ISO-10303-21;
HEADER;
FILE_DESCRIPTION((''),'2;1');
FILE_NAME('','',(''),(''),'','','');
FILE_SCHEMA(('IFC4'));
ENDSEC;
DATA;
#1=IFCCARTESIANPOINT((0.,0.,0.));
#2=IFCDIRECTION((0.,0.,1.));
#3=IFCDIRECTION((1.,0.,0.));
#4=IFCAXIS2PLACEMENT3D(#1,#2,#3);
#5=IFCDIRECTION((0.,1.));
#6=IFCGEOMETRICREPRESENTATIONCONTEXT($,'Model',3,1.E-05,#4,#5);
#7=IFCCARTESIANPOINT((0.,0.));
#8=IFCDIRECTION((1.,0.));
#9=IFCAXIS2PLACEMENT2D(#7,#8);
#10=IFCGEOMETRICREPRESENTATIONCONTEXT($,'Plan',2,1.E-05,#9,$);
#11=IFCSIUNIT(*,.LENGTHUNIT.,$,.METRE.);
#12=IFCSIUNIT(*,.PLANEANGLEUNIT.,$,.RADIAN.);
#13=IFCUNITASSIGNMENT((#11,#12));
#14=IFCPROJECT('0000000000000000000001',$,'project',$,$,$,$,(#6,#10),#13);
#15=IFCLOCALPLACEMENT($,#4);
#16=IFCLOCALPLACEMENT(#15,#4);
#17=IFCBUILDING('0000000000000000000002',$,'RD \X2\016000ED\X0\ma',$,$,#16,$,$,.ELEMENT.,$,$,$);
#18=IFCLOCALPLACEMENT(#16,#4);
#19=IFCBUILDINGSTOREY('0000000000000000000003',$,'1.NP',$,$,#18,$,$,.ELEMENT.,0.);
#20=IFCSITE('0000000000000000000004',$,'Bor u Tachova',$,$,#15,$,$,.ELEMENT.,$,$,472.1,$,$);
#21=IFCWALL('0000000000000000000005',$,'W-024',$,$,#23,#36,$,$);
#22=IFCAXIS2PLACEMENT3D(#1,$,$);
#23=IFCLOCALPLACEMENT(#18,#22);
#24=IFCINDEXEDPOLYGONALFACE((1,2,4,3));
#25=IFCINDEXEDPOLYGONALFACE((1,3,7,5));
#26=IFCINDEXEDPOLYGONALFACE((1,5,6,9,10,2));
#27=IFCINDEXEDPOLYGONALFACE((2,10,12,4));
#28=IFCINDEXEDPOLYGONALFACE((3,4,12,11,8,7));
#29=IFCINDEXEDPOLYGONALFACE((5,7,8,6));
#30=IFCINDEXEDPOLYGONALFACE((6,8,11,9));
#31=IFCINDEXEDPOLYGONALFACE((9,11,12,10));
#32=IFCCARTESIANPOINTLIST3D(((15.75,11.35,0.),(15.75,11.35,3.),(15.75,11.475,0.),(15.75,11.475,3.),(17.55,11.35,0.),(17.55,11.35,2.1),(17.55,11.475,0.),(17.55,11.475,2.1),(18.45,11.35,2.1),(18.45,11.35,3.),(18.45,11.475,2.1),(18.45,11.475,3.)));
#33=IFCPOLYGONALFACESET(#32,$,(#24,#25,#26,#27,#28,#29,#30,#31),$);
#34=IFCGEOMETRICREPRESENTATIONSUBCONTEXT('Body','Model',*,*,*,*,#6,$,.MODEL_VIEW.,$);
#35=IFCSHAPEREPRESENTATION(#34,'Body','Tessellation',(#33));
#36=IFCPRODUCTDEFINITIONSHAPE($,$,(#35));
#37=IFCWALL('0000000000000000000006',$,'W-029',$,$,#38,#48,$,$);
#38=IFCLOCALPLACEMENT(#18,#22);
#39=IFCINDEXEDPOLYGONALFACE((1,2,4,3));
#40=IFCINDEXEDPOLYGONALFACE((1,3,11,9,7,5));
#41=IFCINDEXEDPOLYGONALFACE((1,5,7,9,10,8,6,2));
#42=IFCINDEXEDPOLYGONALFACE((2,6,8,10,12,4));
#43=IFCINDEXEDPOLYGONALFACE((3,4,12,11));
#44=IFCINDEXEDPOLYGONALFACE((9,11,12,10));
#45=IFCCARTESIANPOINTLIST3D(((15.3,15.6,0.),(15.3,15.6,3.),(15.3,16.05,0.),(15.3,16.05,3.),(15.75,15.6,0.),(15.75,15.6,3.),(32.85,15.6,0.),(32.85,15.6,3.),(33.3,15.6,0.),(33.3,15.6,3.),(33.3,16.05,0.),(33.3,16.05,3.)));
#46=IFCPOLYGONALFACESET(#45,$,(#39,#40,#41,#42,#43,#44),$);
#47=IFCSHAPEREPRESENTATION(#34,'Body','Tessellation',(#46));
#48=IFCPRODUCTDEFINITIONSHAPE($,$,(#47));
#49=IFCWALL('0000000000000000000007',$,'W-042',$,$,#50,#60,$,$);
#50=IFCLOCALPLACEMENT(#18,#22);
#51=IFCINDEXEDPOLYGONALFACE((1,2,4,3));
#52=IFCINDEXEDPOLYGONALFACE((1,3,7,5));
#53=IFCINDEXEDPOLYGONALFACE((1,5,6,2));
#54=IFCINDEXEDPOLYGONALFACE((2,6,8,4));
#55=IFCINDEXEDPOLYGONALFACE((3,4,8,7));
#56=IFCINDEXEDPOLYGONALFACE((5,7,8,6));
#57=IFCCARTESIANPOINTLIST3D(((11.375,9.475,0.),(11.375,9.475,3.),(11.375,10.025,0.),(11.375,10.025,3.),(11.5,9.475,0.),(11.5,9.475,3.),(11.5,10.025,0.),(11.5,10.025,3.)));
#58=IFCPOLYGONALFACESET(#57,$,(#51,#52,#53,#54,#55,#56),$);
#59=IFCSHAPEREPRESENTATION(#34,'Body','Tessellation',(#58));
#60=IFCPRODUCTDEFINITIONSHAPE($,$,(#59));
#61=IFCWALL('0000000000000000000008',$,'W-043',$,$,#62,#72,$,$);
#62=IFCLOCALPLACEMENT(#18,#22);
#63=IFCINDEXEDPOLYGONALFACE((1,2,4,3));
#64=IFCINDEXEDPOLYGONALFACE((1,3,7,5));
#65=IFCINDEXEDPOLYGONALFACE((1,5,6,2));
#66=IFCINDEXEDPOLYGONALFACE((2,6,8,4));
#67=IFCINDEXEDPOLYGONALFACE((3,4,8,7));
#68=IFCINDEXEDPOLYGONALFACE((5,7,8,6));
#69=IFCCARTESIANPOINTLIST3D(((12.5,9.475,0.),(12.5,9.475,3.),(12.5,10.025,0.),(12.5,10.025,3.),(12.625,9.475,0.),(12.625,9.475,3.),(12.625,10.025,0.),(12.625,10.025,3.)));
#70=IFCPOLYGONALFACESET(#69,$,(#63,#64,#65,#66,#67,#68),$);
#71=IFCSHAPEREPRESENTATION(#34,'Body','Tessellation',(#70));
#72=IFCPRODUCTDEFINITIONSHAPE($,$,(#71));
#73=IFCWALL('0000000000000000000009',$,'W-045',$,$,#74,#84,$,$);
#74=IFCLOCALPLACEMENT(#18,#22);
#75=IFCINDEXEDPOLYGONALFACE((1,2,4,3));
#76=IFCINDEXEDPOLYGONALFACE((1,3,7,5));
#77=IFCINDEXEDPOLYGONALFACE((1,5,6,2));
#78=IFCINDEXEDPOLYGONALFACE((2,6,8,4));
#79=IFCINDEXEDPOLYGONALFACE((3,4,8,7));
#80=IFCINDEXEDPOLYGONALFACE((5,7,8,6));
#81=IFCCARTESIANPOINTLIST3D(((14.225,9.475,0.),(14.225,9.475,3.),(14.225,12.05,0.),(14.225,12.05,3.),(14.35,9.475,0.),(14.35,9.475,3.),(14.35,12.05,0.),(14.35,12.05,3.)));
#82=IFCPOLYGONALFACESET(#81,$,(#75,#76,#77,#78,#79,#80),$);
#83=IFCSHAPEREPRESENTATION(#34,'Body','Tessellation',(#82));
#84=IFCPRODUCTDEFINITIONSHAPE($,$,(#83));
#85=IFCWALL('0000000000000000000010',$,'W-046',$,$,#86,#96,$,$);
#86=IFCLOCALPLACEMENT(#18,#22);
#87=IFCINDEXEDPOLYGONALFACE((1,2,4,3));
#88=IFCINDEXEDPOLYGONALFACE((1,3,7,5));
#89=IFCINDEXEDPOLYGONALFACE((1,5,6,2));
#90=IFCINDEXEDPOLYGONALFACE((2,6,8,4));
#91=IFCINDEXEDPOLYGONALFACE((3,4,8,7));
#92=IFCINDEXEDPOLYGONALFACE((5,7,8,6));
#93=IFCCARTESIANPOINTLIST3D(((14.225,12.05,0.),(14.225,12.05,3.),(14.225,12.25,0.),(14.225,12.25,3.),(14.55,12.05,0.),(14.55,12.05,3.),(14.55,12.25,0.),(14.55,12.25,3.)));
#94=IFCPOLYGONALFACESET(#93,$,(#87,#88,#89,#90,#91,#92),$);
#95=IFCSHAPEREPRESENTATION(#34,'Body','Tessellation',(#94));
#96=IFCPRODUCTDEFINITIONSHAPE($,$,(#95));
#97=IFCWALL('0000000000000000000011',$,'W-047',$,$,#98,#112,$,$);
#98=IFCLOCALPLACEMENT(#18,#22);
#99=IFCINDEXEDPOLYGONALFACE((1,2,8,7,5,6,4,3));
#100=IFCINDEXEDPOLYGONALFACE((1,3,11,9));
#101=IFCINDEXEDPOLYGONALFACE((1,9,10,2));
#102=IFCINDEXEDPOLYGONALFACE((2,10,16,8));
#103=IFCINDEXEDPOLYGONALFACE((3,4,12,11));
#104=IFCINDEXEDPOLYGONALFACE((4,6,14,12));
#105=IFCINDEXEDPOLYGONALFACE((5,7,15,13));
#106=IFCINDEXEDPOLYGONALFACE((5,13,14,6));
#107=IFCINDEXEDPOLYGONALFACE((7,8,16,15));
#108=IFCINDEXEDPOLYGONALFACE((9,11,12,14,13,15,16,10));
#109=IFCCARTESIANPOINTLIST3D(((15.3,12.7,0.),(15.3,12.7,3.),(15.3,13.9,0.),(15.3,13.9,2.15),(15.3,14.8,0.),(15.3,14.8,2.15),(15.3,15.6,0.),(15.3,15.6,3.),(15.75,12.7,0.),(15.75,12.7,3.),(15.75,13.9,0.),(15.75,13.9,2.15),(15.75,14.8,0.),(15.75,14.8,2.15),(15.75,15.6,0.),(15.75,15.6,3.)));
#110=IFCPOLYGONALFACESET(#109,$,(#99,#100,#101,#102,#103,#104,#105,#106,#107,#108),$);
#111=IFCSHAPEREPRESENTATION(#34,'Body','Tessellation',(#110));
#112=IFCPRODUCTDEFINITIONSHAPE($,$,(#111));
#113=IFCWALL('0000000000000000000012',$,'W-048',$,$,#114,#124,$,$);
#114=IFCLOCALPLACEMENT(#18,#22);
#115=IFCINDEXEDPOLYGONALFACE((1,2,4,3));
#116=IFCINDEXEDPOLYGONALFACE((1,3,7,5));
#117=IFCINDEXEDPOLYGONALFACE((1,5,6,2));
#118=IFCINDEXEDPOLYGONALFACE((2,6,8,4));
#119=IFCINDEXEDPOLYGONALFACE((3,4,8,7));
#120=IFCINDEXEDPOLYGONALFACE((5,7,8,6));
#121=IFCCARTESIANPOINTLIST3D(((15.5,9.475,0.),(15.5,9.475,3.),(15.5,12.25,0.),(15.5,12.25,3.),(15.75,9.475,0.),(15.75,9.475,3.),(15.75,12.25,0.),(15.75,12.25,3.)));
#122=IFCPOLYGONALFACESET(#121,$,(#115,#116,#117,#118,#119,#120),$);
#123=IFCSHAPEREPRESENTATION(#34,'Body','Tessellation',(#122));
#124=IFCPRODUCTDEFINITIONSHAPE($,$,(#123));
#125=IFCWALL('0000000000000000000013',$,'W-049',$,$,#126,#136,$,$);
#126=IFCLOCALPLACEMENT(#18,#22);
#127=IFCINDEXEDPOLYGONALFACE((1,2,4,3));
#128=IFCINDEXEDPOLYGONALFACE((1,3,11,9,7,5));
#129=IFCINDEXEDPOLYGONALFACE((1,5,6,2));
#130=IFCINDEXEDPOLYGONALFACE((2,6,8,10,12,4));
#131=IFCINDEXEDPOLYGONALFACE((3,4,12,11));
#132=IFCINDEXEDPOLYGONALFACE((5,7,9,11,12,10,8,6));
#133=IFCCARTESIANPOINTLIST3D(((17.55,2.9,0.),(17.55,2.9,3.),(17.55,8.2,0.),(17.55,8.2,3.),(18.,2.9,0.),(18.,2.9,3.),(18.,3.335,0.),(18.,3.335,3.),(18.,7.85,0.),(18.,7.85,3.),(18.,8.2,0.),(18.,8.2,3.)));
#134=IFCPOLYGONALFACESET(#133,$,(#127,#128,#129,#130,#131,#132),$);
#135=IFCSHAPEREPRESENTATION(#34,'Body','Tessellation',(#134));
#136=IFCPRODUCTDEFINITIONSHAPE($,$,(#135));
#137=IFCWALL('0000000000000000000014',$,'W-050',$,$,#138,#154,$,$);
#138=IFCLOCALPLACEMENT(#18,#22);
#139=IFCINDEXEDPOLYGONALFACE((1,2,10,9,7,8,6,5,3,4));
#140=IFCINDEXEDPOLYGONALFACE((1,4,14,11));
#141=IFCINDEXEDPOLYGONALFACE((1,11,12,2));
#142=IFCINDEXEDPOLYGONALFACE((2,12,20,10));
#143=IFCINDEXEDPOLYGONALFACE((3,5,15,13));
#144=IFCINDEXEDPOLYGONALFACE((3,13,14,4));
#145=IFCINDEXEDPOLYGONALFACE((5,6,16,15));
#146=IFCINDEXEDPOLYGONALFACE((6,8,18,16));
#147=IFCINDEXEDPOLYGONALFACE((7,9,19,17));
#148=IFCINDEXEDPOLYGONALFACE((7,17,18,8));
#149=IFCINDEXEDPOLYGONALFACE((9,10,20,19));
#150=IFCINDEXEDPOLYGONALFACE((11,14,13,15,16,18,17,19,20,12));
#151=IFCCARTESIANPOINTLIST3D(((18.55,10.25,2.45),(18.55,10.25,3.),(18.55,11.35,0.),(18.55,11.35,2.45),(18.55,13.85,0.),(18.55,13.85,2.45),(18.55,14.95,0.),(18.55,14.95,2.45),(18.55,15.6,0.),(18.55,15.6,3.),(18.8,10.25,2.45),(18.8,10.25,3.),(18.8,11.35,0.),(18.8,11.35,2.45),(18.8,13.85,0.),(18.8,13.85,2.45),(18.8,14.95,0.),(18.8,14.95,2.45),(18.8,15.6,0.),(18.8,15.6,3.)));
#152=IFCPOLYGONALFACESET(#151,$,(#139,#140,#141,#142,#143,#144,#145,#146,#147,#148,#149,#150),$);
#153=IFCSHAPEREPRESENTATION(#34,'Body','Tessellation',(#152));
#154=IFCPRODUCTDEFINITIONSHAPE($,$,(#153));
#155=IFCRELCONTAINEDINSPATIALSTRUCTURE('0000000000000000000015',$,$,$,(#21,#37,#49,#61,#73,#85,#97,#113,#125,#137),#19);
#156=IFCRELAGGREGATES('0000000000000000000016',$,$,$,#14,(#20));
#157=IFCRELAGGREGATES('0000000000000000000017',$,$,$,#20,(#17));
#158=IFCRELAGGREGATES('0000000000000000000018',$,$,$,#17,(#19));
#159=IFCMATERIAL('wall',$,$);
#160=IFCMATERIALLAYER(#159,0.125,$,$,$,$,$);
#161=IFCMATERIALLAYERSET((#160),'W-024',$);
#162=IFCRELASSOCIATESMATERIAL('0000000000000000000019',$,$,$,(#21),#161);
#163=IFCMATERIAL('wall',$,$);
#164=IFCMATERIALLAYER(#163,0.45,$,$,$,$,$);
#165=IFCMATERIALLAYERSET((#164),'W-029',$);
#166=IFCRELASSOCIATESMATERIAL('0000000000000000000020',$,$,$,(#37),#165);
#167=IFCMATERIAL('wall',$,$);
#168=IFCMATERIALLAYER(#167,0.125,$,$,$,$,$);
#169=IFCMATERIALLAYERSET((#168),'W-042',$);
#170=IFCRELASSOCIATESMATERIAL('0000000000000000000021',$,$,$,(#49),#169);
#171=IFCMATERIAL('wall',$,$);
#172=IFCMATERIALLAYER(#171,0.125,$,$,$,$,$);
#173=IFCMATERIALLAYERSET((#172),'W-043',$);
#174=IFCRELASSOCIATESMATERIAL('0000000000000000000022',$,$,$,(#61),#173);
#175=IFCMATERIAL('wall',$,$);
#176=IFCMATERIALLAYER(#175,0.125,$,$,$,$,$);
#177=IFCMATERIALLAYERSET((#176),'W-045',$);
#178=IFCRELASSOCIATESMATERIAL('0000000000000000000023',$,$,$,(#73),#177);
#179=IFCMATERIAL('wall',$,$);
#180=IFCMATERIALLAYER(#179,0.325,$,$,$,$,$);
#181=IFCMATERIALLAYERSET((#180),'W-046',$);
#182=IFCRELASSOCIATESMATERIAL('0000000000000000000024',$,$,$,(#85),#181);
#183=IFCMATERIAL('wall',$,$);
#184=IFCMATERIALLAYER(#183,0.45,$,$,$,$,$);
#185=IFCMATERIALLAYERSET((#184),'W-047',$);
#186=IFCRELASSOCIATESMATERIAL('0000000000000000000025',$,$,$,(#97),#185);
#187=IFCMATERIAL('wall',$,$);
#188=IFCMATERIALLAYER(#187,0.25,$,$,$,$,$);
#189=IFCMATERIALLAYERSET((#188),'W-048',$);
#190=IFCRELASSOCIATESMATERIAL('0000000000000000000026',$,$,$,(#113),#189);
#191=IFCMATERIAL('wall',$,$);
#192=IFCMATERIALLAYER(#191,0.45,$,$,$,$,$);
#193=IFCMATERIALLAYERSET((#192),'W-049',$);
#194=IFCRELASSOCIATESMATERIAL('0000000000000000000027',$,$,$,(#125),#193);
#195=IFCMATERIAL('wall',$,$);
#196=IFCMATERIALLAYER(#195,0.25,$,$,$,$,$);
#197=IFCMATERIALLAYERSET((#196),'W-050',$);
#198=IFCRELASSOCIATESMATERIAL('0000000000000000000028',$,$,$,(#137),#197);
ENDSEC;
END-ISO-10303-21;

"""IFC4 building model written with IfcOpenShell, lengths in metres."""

from ifc_helpers import new_model, si_unit, direction, frame, frame_2d, origin_with_axes, origin_2d_with_axis, place, context, subcontext, project, spatial, line, indexed_curve, rectangle, outline, extrude, material, layer, layer_set, layer_usage, element, save


model = new_model("IFC4")

# Units and contexts
model_context = context("Model", 3, precision=1e-05, world=origin_with_axes(), true_north=direction((0.0, 1.0)))
plan_context = context("Plan", 2, precision=1e-05, world=origin_2d_with_axis())
body_context = subcontext(model_context, "Body", "Model", "MODEL_VIEW")
ifc_project = project(units=[si_unit("LENGTHUNIT", "METRE"), si_unit("PLANEANGLEUNIT", "RADIAN")], contexts=[model_context, plan_context])

# Site, building, storey
site_placement = place(None, origin_with_axes())
site = spatial("IfcSite", under=ifc_project, at=site_placement, Name="Bor u Tachova", CompositionType="ELEMENT", RefElevation=472.1)
building_placement = place(site_placement, origin_with_axes())
building = spatial("IfcBuilding", under=site, at=building_placement, Name="RD Šíma", CompositionType="ELEMENT")
storey_placement = place(building_placement, origin_with_axes())
storey = spatial("IfcBuildingStorey", under=building, at=storey_placement, Name="1.NP", CompositionType="ELEMENT", Elevation=0.0)

# Wall, opening
ifc_material_1 = material(Name="wall")
ifc_layer_1 = layer(ifc_material_1, 0.125)
ifc_layer_set_1 = layer_set([ifc_layer_1], Name="W-024")
ifc_layer_usage_1 = layer_usage(ifc_layer_set_1, "AXIS2", "POSITIVE", -0.0625)
wall_1_placement = place(storey_placement, frame((15.625, 11.4125, 0.0), z_axis=(0.0, 0.0, 1.0), x_axis=(1.0, 0.0, 0.0)))
wall_1 = element("IfcWall", 1, at=wall_1_placement, inside=storey, material=ifc_layer_usage_1, Name="W-024", context=body_context, shape_type="SweptSolid", body=[
    extrude(outline(indexed_curve([(0.125, -0.0625), (0.125, 0.0625), (2.825, 0.0625), (2.825, -0.0625)], segments=[line(1, 2, 3, 4, 1)])), origin_with_axes(), (0.0, 0.0, 1.0), 3.0),
])
opening_1_placement = place(wall_1_placement, frame((1.925, 0.0, 0.0), z_axis=(0.0, 0.0, 1.0), x_axis=(1.0, 0.0, 0.0)))
element("IfcOpeningElement", 2, at=opening_1_placement, cuts=wall_1, PredefinedType="OPENING", context=body_context, shape_type="SweptSolid", body=[
    extrude(rectangle(XDim=0.9, YDim=0.125, at=frame_2d((0.45, 0.0))), origin_with_axes(), (0.0, 0.0, 1.0), 2.1),
])

# Walls
ifc_material_2 = material(Name="wall")
ifc_layer_2 = layer(ifc_material_2, 0.45)
ifc_layer_set_2 = layer_set([ifc_layer_2], Name="W-029")
ifc_layer_usage_2 = layer_usage(ifc_layer_set_2, "AXIS2", "POSITIVE", -0.225)
wall_2_placement = place(storey_placement, frame((15.525, 15.825, 0.0), z_axis=(0.0, 0.0, 1.0), x_axis=(1.0, 0.0, 0.0)))
element("IfcWall", 3, at=wall_2_placement, inside=storey, material=ifc_layer_usage_2, Name="W-029", context=body_context, shape_type="SweptSolid", body=[
    extrude(outline(indexed_curve([(0.225, -0.225), (-0.225, -0.225), (-0.225, 0.225), (17.775, 0.225), (17.775, -0.225), (17.325, -0.225)], segments=[line(1, 2, 3, 4, 5, 6, 1)])), origin_with_axes(), (0.0, 0.0, 1.0), 3.0),
])
ifc_material_3 = material(Name="wall")
ifc_layer_3 = layer(ifc_material_3, 0.125)
ifc_layer_set_3 = layer_set([ifc_layer_3], Name="W-042")
ifc_layer_usage_3 = layer_usage(ifc_layer_set_3, "AXIS2", "POSITIVE", -0.0625)
wall_3_placement = place(storey_placement, frame((11.4375, 9.475, 0.0), z_axis=(0.0, 0.0, 1.0), x_axis=(0.0, 1.0, 0.0)))
element("IfcWall", 4, at=wall_3_placement, inside=storey, material=ifc_layer_usage_3, Name="W-042", context=body_context, shape_type="SweptSolid", body=[
    extrude(outline(indexed_curve([(0.0, -0.0625), (0.0, 0.0625), (0.55, 0.0625), (0.55, -0.0625)], segments=[line(1, 2, 3, 4, 1)])), origin_with_axes(), (0.0, 0.0, 1.0), 3.0),
])
ifc_material_4 = material(Name="wall")
ifc_layer_4 = layer(ifc_material_4, 0.125)
ifc_layer_set_4 = layer_set([ifc_layer_4], Name="W-043")
ifc_layer_usage_4 = layer_usage(ifc_layer_set_4, "AXIS2", "POSITIVE", -0.0625)
wall_4_placement = place(storey_placement, frame((12.5625, 9.475, 0.0), z_axis=(0.0, 0.0, 1.0), x_axis=(0.0, 1.0, 0.0)))
element("IfcWall", 5, at=wall_4_placement, inside=storey, material=ifc_layer_usage_4, Name="W-043", context=body_context, shape_type="SweptSolid", body=[
    extrude(outline(indexed_curve([(0.0, -0.0625), (0.0, 0.0625), (0.55, 0.0625), (0.55, -0.0625)], segments=[line(1, 2, 3, 4, 1)])), origin_with_axes(), (0.0, 0.0, 1.0), 3.0),
])
ifc_material_5 = material(Name="wall")
ifc_layer_5 = layer(ifc_material_5, 0.125)
ifc_layer_set_5 = layer_set([ifc_layer_5], Name="W-045")
ifc_layer_usage_5 = layer_usage(ifc_layer_set_5, "AXIS2", "POSITIVE", -0.0625)
wall_5_placement = place(storey_placement, frame((14.2875, 9.475, 0.0), z_axis=(0.0, 0.0, 1.0), x_axis=(0.0, 1.0, 0.0)))
element("IfcWall", 6, at=wall_5_placement, inside=storey, material=ifc_layer_usage_5, Name="W-045", context=body_context, shape_type="SweptSolid", body=[
    extrude(outline(indexed_curve([(0.0, -0.0625), (0.0, 0.0625), (2.575, 0.0625), (2.575, -0.0625)], segments=[line(1, 2, 3, 4, 1)])), origin_with_axes(), (0.0, 0.0, 1.0), 3.0),
])
ifc_material_6 = material(Name="wall")
ifc_layer_6 = layer(ifc_material_6, 0.325)
ifc_layer_set_6 = layer_set([ifc_layer_6], Name="W-046")
ifc_layer_usage_6 = layer_usage(ifc_layer_set_6, "AXIS2", "POSITIVE", -0.1625)
wall_6_placement = place(storey_placement, frame((14.3875, 12.05, 0.0), z_axis=(0.0, 0.0, 1.0), x_axis=(0.0, 1.0, 0.0)))
element("IfcWall", 7, at=wall_6_placement, inside=storey, material=ifc_layer_usage_6, Name="W-046", context=body_context, shape_type="SweptSolid", body=[
    extrude(outline(indexed_curve([(0.0, -0.1625), (0.0, 0.1625), (0.2, 0.1625), (0.2, -0.1625)], segments=[line(1, 2, 3, 4, 1)])), origin_with_axes(), (0.0, 0.0, 1.0), 3.0),
])

# Wall, opening
ifc_material_7 = material(Name="wall")
ifc_layer_7 = layer(ifc_material_7, 0.45)
ifc_layer_set_7 = layer_set([ifc_layer_7], Name="W-047")
ifc_layer_usage_7 = layer_usage(ifc_layer_set_7, "AXIS2", "POSITIVE", -0.225)
wall_7_placement = place(storey_placement, frame((15.525, 12.475, 0.0), z_axis=(0.0, 0.0, 1.0), x_axis=(0.0, 1.0, 0.0)))
wall_7 = element("IfcWall", 8, at=wall_7_placement, inside=storey, material=ifc_layer_usage_7, Name="W-047", context=body_context, shape_type="SweptSolid", body=[
    extrude(outline(indexed_curve([(0.225, -0.225), (0.225, 0.225), (3.125, 0.225), (3.125, -0.225)], segments=[line(1, 2, 3, 4, 1)])), origin_with_axes(), (0.0, 0.0, 1.0), 3.0),
])
opening_2_placement = place(wall_7_placement, frame((1.425, 0.0, 0.0), z_axis=(0.0, 0.0, 1.0), x_axis=(1.0, 0.0, 0.0)))
element("IfcOpeningElement", 9, at=opening_2_placement, cuts=wall_7, PredefinedType="OPENING", context=body_context, shape_type="SweptSolid", body=[
    extrude(rectangle(XDim=0.9, YDim=0.45, at=frame_2d((0.45, 0.0))), origin_with_axes(), (0.0, 0.0, 1.0), 2.15),
])

# Walls
ifc_material_8 = material(Name="wall")
ifc_layer_8 = layer(ifc_material_8, 0.25)
ifc_layer_set_8 = layer_set([ifc_layer_8], Name="W-048")
ifc_layer_usage_8 = layer_usage(ifc_layer_set_8, "AXIS2", "POSITIVE", -0.125)
wall_8_placement = place(storey_placement, frame((15.625, 9.475, 0.0), z_axis=(0.0, 0.0, 1.0), x_axis=(0.0, 1.0, 0.0)))
element("IfcWall", 10, at=wall_8_placement, inside=storey, material=ifc_layer_usage_8, Name="W-048", context=body_context, shape_type="SweptSolid", body=[
    extrude(outline(indexed_curve([(0.0, -0.125), (0.0, 0.125), (2.775, 0.125), (2.775, -0.125)], segments=[line(1, 2, 3, 4, 1)])), origin_with_axes(), (0.0, 0.0, 1.0), 3.0),
])
ifc_material_9 = material(Name="wall")
ifc_layer_9 = layer(ifc_material_9, 0.45)
ifc_layer_set_9 = layer_set([ifc_layer_9], Name="W-049")
ifc_layer_usage_9 = layer_usage(ifc_layer_set_9, "AXIS2", "POSITIVE", -0.225)
wall_9_placement = place(storey_placement, frame((17.775, 3.1175, 0.0), z_axis=(0.0, 0.0, 1.0), x_axis=(0.0, 1.0, 0.0)))
element("IfcWall", 11, at=wall_9_placement, inside=storey, material=ifc_layer_usage_9, Name="W-049", context=body_context, shape_type="SweptSolid", body=[
    extrude(outline(indexed_curve([(0.2175, -0.225), (-0.2175, -0.225), (-0.2175, 0.225), (5.0825, 0.225), (5.0825, -0.225), (4.7325, -0.225)], segments=[line(1, 2, 3, 4, 5, 6, 1)])), origin_with_axes(), (0.0, 0.0, 1.0), 3.0),
])

# Wall, openings
ifc_material_10 = material(Name="wall")
ifc_layer_10 = layer(ifc_material_10, 0.25)
ifc_layer_set_10 = layer_set([ifc_layer_10], Name="W-050")
ifc_layer_usage_10 = layer_usage(ifc_layer_set_10, "AXIS2", "POSITIVE", -0.125)
wall_10_placement = place(storey_placement, frame((18.675, 10.25, 0.0), z_axis=(0.0, 0.0, 1.0), x_axis=(0.0, 1.0, 0.0)))
wall_10 = element("IfcWall", 12, at=wall_10_placement, inside=storey, material=ifc_layer_usage_10, Name="W-050", context=body_context, shape_type="SweptSolid", body=[
    extrude(outline(indexed_curve([(0.0, -0.125), (0.0, 0.125), (5.35, 0.125), (5.35, -0.125)], segments=[line(1, 2, 3, 4, 1)])), origin_with_axes(), (0.0, 0.0, 1.0), 3.0),
])
opening_3_placement = place(wall_10_placement, origin_with_axes())
element("IfcOpeningElement", 13, at=opening_3_placement, cuts=wall_10, PredefinedType="OPENING", context=body_context, shape_type="SweptSolid", body=[
    extrude(rectangle(XDim=1.1, YDim=0.25, at=frame_2d((0.55, 0.0))), origin_with_axes(), (0.0, 0.0, 1.0), 2.45),
])
opening_4_placement = place(wall_10_placement, frame((3.6, 0.0, 0.0), z_axis=(0.0, 0.0, 1.0), x_axis=(1.0, 0.0, 0.0)))
element("IfcOpeningElement", 14, at=opening_4_placement, cuts=wall_10, PredefinedType="OPENING", context=body_context, shape_type="SweptSolid", body=[
    extrude(rectangle(XDim=1.1, YDim=0.25, at=frame_2d((0.55, 0.0))), origin_with_axes(), (0.0, 0.0, 1.0), 2.45),
])

save(model, "model.ifc")
